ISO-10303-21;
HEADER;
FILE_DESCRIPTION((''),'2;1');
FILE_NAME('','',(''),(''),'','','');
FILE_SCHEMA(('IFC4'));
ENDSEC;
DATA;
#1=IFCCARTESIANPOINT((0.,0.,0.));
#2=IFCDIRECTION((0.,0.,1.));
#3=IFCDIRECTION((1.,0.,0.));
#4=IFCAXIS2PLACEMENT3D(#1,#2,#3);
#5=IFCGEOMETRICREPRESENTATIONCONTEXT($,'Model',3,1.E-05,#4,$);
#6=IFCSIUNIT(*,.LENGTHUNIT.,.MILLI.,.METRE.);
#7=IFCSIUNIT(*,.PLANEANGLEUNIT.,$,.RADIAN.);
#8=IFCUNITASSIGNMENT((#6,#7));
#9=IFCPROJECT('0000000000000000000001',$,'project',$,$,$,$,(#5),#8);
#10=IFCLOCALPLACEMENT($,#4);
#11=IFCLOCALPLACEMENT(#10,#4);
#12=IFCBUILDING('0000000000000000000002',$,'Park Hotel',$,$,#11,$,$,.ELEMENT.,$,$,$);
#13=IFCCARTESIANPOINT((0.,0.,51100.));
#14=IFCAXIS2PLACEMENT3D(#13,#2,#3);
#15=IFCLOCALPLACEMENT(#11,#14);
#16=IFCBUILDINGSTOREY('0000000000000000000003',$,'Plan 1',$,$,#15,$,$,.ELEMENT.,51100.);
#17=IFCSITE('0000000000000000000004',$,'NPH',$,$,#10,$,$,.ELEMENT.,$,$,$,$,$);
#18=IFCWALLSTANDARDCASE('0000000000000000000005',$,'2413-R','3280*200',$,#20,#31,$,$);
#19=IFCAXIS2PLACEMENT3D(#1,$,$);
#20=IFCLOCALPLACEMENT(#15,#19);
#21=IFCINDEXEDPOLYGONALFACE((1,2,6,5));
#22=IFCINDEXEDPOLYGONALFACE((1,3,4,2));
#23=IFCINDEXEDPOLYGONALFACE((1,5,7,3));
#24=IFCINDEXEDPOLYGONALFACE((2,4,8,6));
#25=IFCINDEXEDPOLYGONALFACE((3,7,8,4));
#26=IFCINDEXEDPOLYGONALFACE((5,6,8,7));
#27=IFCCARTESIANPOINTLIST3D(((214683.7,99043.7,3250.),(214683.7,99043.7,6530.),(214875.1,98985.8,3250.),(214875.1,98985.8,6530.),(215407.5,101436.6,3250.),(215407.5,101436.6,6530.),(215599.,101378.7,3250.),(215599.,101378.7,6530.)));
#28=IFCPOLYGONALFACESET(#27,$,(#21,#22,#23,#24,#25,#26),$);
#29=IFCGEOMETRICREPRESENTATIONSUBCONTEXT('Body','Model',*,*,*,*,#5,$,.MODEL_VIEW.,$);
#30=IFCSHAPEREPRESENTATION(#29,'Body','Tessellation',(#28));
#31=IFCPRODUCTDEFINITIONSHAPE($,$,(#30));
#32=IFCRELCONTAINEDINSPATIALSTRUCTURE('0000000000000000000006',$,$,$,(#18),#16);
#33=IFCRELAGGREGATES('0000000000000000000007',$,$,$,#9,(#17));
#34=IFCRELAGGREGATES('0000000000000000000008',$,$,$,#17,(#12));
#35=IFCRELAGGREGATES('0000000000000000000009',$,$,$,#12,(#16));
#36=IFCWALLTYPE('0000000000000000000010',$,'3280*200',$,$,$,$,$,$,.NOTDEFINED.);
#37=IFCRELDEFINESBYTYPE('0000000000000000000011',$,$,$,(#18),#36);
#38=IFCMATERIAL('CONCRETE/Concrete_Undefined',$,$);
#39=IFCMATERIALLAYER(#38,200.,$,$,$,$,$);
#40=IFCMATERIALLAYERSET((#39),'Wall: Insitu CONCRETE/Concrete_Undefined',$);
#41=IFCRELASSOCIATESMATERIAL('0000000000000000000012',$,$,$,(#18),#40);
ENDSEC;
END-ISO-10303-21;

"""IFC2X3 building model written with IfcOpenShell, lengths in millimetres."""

from ifc_helpers import new_model, si_unit, frame, frame_2d, origin_with_axes, place, context, subcontext, project, spatial, rectangle, extrude, material, layer, layer_set, layer_usage, type_object, element, save


model = new_model("IFC2X3")

# Units and contexts
model_context = context("Model", 3, precision=1e-05, world=origin_with_axes())
body_context = subcontext(model_context, "Body", "Model", "MODEL_VIEW")
ifc_project = project(units=[si_unit("LENGTHUNIT", "METRE", prefix="MILLI"), si_unit("PLANEANGLEUNIT", "RADIAN")], contexts=[model_context])

# Site, building, storey
site_placement = place(None, origin_with_axes())
site = spatial("IfcSite", under=ifc_project, at=site_placement, Name="NPH", CompositionType="ELEMENT")
building_placement = place(site_placement, origin_with_axes())
building = spatial("IfcBuilding", under=site, at=building_placement, Name="Park Hotel", CompositionType="ELEMENT")
storey_placement = place(building_placement, frame((0.0, 0.0, 51100.0), z_axis=(0.0, 0.0, 1.0), x_axis=(1.0, 0.0, 0.0)))
storey = spatial("IfcBuildingStorey", under=building, at=storey_placement, Name="Plan 1", CompositionType="ELEMENT", Elevation=51100.0)

# Shared definitions
ifc_material_1 = material(Name="CONCRETE/Concrete_Undefined")

# Wall
ifc_layer_1 = layer(ifc_material_1, 200.0)
ifc_layer_set_1 = layer_set([ifc_layer_1], Name="Wall: Insitu CONCRETE/Concrete_Undefined")
ifc_layer_usage_1 = layer_usage(ifc_layer_set_1, "AXIS2", "POSITIVE", -100.0)
wall_type_1 = type_object("IfcWallType", Name="3280*200", PredefinedType="NOTDEFINED")
wall_1_placement = place(storey_placement, frame((214779.4, 99014.7, 3250.0), z_axis=(0.0, 0.0, 1.0), x_axis=(0.289536, 0.957167, 0.0)))
element("IfcWallStandardCase", 1, at=wall_1_placement, inside=storey, type_object=wall_type_1, material=ifc_layer_usage_1, Name="2413-R", Description="3280*200", context=body_context, shape_type="SweptSolid", body=[
    extrude(rectangle(XDim=2500.0, YDim=200.0, at=frame_2d((0.0, 1250.0), x_axis=(0.0, -1.0))), frame((0.0, 0.0, 0.0), z_axis=(0.0, 0.0, 1.0), x_axis=(0.0, -1.0, 0.0)), (0.0, 0.0, 1.0), 3280.0),
])

save(model, "model.ifc")
